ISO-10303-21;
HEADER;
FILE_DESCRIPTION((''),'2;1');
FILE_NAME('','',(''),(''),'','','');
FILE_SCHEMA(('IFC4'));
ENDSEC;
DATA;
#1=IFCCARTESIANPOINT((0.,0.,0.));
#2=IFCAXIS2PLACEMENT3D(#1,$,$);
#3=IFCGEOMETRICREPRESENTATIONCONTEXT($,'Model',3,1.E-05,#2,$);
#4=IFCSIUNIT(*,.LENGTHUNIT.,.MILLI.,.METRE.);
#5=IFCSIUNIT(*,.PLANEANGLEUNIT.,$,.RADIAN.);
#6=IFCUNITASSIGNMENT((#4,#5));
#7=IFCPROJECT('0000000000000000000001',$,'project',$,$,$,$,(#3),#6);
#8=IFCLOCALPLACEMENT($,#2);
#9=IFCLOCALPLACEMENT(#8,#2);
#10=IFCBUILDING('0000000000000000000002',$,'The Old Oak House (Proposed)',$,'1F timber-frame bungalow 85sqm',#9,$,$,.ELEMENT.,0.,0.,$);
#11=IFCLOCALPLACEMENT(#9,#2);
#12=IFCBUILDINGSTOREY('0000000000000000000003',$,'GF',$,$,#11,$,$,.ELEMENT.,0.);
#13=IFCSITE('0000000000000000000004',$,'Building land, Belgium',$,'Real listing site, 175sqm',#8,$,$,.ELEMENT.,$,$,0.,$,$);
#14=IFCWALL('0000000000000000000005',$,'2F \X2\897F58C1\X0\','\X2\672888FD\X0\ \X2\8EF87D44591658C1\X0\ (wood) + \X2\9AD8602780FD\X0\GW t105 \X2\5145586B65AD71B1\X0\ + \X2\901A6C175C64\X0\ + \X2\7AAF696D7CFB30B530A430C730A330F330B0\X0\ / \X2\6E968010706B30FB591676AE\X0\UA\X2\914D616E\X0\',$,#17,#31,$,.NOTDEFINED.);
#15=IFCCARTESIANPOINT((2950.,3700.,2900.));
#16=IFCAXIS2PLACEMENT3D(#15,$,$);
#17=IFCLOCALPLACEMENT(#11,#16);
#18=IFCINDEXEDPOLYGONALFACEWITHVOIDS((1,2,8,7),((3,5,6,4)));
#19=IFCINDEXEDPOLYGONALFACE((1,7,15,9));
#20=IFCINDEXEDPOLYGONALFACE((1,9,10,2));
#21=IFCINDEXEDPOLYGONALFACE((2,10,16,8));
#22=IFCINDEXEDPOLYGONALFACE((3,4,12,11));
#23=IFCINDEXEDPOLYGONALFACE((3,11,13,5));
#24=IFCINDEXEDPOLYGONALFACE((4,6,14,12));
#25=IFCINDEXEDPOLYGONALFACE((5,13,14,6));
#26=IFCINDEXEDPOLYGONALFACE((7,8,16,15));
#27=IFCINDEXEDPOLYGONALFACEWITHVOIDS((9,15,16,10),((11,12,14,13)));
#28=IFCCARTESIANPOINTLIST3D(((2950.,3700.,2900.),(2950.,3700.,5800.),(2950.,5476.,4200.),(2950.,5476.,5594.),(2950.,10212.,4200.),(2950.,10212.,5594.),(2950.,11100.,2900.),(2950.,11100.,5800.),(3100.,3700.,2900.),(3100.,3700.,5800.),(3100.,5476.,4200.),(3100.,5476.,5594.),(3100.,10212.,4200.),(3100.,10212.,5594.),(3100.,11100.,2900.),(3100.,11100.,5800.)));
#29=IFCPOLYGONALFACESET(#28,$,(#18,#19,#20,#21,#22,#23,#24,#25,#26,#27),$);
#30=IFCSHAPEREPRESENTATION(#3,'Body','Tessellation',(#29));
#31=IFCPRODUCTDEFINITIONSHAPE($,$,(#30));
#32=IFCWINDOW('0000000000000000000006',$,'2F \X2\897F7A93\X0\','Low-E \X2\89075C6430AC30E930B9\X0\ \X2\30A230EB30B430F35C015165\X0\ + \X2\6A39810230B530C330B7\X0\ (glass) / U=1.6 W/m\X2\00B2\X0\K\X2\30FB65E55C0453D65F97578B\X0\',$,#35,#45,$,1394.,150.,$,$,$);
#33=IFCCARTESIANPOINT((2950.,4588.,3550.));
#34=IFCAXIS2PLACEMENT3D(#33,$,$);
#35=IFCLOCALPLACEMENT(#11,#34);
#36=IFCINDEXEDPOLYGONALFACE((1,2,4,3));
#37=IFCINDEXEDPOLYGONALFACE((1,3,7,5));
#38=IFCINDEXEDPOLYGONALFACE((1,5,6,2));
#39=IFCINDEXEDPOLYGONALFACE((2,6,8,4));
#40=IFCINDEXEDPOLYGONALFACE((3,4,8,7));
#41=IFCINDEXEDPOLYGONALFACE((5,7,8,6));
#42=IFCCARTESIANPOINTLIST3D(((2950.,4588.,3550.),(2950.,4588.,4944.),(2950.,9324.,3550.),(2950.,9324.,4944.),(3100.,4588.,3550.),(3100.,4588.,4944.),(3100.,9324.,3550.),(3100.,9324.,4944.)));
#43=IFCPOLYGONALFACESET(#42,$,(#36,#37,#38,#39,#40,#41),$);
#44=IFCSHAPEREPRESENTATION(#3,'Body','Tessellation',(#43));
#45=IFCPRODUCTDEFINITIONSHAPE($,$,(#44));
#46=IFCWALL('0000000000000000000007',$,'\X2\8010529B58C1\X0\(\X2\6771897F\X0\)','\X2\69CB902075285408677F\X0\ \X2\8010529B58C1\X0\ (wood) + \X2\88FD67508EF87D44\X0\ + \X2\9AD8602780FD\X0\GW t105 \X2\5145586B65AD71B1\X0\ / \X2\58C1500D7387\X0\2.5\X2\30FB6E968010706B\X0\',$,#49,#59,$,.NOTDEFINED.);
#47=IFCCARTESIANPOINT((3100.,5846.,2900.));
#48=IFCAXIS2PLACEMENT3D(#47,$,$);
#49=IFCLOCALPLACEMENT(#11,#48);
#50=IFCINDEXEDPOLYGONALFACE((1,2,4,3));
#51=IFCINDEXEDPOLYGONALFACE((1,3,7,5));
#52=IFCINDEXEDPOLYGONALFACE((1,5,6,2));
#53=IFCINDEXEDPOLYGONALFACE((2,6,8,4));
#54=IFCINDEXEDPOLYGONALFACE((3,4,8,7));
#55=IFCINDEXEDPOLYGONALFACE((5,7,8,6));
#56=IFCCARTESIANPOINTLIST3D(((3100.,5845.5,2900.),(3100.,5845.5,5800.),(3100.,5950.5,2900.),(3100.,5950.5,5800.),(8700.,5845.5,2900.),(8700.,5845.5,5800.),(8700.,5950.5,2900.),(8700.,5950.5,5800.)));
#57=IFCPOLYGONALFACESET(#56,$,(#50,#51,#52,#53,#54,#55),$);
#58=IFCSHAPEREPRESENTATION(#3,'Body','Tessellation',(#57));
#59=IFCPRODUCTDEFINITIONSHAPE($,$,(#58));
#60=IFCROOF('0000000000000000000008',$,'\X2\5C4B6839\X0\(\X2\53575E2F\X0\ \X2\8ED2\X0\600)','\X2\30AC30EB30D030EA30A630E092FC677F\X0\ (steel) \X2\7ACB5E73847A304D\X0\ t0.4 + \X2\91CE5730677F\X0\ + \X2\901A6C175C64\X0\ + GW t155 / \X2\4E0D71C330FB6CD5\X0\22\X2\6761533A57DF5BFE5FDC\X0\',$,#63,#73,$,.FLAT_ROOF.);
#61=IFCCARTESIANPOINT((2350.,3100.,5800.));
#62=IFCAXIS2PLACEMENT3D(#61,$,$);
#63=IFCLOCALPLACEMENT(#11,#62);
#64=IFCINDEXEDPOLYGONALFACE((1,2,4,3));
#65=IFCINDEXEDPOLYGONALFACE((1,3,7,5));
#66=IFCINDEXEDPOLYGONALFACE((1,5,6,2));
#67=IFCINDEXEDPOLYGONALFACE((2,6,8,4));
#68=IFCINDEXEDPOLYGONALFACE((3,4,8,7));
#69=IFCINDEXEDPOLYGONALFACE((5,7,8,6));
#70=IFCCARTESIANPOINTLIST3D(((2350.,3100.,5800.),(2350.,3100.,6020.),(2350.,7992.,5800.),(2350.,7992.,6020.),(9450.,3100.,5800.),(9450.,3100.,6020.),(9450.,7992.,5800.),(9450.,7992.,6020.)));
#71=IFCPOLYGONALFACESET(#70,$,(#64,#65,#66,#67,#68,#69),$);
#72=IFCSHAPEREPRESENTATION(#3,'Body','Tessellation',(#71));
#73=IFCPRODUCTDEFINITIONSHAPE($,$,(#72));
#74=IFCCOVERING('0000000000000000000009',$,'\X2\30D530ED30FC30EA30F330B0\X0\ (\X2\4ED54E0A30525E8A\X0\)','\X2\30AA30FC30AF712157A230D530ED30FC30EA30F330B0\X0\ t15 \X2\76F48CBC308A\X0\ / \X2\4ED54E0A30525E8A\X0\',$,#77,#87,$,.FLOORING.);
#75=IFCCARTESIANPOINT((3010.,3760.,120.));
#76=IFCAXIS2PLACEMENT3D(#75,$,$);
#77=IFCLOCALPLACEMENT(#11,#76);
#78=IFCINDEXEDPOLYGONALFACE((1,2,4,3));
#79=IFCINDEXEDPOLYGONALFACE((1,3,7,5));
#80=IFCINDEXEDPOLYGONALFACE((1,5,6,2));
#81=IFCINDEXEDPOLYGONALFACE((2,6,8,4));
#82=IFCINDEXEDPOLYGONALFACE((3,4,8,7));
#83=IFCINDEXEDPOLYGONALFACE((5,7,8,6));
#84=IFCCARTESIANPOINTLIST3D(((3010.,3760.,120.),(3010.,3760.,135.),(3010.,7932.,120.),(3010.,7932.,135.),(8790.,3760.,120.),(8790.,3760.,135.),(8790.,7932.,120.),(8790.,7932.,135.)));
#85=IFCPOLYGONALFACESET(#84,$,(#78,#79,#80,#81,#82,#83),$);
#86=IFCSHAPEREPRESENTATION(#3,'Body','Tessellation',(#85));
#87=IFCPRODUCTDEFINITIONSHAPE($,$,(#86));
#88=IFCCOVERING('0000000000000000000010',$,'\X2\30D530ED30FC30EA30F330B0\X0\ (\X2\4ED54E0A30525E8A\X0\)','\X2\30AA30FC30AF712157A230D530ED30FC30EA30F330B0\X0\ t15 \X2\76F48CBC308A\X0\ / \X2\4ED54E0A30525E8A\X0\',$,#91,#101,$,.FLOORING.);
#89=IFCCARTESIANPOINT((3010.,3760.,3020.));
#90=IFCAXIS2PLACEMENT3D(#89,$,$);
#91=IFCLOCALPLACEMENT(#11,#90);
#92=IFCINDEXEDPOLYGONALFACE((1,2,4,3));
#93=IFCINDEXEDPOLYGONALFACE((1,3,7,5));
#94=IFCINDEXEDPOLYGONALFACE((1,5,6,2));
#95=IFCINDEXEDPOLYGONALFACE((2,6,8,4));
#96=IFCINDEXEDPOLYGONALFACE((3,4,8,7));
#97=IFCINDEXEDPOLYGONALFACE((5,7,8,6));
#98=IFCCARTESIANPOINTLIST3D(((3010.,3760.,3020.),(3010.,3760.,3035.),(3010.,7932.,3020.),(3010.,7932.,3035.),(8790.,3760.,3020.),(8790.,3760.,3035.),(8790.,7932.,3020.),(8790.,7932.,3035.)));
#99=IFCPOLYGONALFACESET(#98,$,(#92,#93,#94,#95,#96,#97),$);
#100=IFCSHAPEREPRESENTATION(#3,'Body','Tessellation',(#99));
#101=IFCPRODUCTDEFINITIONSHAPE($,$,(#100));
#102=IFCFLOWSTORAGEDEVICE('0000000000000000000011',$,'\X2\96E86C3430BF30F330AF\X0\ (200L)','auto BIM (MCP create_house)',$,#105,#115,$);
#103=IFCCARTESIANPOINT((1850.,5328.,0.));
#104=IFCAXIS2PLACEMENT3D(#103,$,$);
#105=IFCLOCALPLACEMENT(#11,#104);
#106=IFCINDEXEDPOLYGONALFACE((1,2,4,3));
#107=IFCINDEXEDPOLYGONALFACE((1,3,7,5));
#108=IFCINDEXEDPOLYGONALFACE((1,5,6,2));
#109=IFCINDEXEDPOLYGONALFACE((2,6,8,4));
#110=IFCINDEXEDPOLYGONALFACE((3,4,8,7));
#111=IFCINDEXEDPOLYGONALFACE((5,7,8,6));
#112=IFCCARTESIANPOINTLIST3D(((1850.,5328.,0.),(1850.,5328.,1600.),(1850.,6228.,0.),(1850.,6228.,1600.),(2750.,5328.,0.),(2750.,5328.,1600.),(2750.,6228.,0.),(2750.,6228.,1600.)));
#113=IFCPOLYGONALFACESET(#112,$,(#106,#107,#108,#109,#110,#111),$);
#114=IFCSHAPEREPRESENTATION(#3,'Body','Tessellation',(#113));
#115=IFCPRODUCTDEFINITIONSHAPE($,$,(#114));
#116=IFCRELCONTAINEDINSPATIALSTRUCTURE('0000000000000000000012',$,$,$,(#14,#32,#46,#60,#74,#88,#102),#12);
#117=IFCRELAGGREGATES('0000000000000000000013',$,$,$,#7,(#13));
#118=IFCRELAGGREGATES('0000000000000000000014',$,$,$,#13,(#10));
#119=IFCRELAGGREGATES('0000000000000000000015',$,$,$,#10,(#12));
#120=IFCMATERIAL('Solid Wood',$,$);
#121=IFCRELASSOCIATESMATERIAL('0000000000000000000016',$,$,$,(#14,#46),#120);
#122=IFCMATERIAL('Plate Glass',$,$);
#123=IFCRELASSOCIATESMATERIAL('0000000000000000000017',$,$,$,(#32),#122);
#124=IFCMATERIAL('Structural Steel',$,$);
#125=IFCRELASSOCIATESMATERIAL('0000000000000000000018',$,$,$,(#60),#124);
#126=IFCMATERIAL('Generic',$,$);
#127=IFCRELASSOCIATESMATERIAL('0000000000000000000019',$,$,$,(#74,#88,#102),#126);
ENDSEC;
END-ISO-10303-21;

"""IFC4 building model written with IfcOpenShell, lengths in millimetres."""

from ifc_helpers import new_model, si_unit, frame, frame_2d, origin, place, context, project, spatial, rectangle, extrude, material, element, fill, save


model = new_model("IFC4")

# Units and contexts
model_context = context("Model", 3, precision=1e-05, world=origin())
ifc_project = project(units=[si_unit("LENGTHUNIT", "METRE", prefix="MILLI"), si_unit("PLANEANGLEUNIT", "RADIAN")], contexts=[model_context])

# Site, building, storey
site_placement = place(None, origin())
site = spatial("IfcSite", under=ifc_project, at=site_placement, Name="Building land, Belgium", ObjectType="Real listing site, 175sqm", CompositionType="ELEMENT", RefElevation=0.0)
building_placement = place(site_placement, origin())
building = spatial("IfcBuilding", under=site, at=building_placement, Name="The Old Oak House (Proposed)", ObjectType="1F timber-frame bungalow 85sqm", CompositionType="ELEMENT", ElevationOfRefHeight=0.0, ElevationOfTerrain=0.0)
storey_placement = place(building_placement, origin())
storey = spatial("IfcBuildingStorey", under=building, at=storey_placement, Name="GF", CompositionType="ELEMENT", Elevation=0.0)

# Shared definitions
ifc_material_1 = material(Name="Solid Wood")
ifc_material_2 = material(Name="Generic")

# Shared definitions
ifc_material_3 = material(Name="Plate Glass")

# Wall, opening, window
wall_1_placement = place(storey_placement, frame((2950.0, 3700.0, 2900.0)))
wall_1 = element("IfcWall", 1, at=wall_1_placement, inside=storey, material=ifc_material_1, Name="2F 西壁", Description="木製 軸組外壁 (wood) + 高性能GW t105 充填断熱 + 通気層 + 窯業系サイディング / 準耐火・外皮UA配慮", PredefinedType="NOTDEFINED", context=model_context, shape_type="SweptSolid", body=[
    extrude(rectangle(XDim=150.0, YDim=7400.0, at=frame_2d((75.0, 3700.0))), frame((2950.0, 3700.0, 2900.0)), (0.0, 0.0, 1.0), 2900.0),
])
opening_1_placement = place(storey_placement, frame((2950.0, 4588.0, 3550.0)))
opening_1 = element("IfcOpeningElement", 2, at=opening_1_placement, cuts=wall_1, PredefinedType="NOTDEFINED", context=model_context, shape_type="SweptSolid", body=[
    extrude(rectangle(XDim=150.0, YDim=4736.0, at=frame_2d((75.0, 2368.0))), frame((2950.0, 4588.0, 3550.0)), (0.0, 0.0, 1.0), 1394.0),
])
window_1_placement = place(storey_placement, frame((2950.0, 4588.0, 3550.0)))
window_1 = element("IfcWindow", 3, at=window_1_placement, inside=storey, material=ifc_material_3, Name="2F 西窓", Description="Low-E 複層ガラス アルゴン封入 + 樹脂サッシ (glass) / U=1.6 W/m²K・日射取得型", OverallHeight=1394.0, OverallWidth=150.0, context=model_context, shape_type="SweptSolid", body=[
    extrude(rectangle(XDim=150.0, YDim=4736.0, at=frame_2d((75.0, 2368.0))), frame((2950.0, 4588.0, 3550.0)), (0.0, 0.0, 1.0), 1394.0),
])
fill(opening_1, window_1)

# Wall
wall_2_placement = place(storey_placement, frame((3100.0, 5846.0, 2900.0)))
element("IfcWall", 4, at=wall_2_placement, inside=storey, material=ifc_material_1, Name="耐力壁(東西)", Description="構造用合板 耐力壁 (wood) + 製材軸組 + 高性能GW t105 充填断熱 / 壁倍率2.5・準耐火", PredefinedType="NOTDEFINED", context=model_context, shape_type="SweptSolid", body=[
    extrude(rectangle(XDim=5600.0, YDim=105.0, at=frame_2d((2800.0, 52.0))), frame((3100.0, 5846.0, 2900.0)), (0.0, 0.0, 1.0), 2900.0),
])

# Roof
ifc_material_4 = material(Name="Structural Steel")
for number, where, name in (
    (5, (2350.0, 3100.0, 5800.0), "屋根(南帯 軒600)"),
):
    element("IfcRoof", number, at=place(storey_placement, frame(where)), inside=storey, material=ifc_material_4, Name=name, Description="ガルバリウム鋼板 (steel) 立平葺き t0.4 + 野地板 + 通気層 + GW t155 / 不燃・法22条区域対応", PredefinedType="FLAT_ROOF", context=model_context, shape_type="SweptSolid", body=[
        extrude(rectangle(XDim=7100.0, YDim=4892.0, at=frame_2d((3550.0, 2446.0))), frame((2350.0, 3100.0, 5800.0)), (0.0, 0.0, 1.0), 220.0),
    ])

# Coverings
covering_1_placement = place(storey_placement, frame((3010.0, 3760.0, 120.0)))
element("IfcCovering", 6, at=covering_1_placement, inside=storey, material=ifc_material_2, Name="フローリング (仕上げ床)", Description="オーク無垢フローリング t15 直貼り / 仕上げ床", PredefinedType="FLOORING", context=model_context, shape_type="SweptSolid", body=[
    extrude(rectangle(XDim=5780.0, YDim=4172.0, at=frame_2d((2890.0, 2086.0))), frame((3010.0, 3760.0, 120.0)), (0.0, 0.0, 1.0), 15.0),
])
covering_2_placement = place(storey_placement, frame((3010.0, 3760.0, 3020.0)))
element("IfcCovering", 7, at=covering_2_placement, inside=storey, material=ifc_material_2, Name="フローリング (仕上げ床)", Description="オーク無垢フローリング t15 直貼り / 仕上げ床", PredefinedType="FLOORING", context=model_context, shape_type="SweptSolid", body=[
    extrude(rectangle(XDim=5780.0, YDim=4172.0, at=frame_2d((2890.0, 2086.0))), frame((3010.0, 3760.0, 3020.0)), (0.0, 0.0, 1.0), 15.0),
])

# Flow storage device
flow_storage_device_placement = place(storey_placement, frame((1850.0, 5328.0, 0.0)))
element("IfcFlowStorageDevice", 8, at=flow_storage_device_placement, inside=storey, material=ifc_material_2, Name="雨水タンク (200L)", Description="auto BIM (MCP create_house)", context=model_context, shape_type="SweptSolid", body=[
    extrude(rectangle(XDim=900.0, YDim=900.0, at=frame_2d((450.0, 450.0))), frame((1850.0, 5328.0, 0.0)), (0.0, 0.0, 1.0), 1600.0),
])

save(model, "model.ifc")
